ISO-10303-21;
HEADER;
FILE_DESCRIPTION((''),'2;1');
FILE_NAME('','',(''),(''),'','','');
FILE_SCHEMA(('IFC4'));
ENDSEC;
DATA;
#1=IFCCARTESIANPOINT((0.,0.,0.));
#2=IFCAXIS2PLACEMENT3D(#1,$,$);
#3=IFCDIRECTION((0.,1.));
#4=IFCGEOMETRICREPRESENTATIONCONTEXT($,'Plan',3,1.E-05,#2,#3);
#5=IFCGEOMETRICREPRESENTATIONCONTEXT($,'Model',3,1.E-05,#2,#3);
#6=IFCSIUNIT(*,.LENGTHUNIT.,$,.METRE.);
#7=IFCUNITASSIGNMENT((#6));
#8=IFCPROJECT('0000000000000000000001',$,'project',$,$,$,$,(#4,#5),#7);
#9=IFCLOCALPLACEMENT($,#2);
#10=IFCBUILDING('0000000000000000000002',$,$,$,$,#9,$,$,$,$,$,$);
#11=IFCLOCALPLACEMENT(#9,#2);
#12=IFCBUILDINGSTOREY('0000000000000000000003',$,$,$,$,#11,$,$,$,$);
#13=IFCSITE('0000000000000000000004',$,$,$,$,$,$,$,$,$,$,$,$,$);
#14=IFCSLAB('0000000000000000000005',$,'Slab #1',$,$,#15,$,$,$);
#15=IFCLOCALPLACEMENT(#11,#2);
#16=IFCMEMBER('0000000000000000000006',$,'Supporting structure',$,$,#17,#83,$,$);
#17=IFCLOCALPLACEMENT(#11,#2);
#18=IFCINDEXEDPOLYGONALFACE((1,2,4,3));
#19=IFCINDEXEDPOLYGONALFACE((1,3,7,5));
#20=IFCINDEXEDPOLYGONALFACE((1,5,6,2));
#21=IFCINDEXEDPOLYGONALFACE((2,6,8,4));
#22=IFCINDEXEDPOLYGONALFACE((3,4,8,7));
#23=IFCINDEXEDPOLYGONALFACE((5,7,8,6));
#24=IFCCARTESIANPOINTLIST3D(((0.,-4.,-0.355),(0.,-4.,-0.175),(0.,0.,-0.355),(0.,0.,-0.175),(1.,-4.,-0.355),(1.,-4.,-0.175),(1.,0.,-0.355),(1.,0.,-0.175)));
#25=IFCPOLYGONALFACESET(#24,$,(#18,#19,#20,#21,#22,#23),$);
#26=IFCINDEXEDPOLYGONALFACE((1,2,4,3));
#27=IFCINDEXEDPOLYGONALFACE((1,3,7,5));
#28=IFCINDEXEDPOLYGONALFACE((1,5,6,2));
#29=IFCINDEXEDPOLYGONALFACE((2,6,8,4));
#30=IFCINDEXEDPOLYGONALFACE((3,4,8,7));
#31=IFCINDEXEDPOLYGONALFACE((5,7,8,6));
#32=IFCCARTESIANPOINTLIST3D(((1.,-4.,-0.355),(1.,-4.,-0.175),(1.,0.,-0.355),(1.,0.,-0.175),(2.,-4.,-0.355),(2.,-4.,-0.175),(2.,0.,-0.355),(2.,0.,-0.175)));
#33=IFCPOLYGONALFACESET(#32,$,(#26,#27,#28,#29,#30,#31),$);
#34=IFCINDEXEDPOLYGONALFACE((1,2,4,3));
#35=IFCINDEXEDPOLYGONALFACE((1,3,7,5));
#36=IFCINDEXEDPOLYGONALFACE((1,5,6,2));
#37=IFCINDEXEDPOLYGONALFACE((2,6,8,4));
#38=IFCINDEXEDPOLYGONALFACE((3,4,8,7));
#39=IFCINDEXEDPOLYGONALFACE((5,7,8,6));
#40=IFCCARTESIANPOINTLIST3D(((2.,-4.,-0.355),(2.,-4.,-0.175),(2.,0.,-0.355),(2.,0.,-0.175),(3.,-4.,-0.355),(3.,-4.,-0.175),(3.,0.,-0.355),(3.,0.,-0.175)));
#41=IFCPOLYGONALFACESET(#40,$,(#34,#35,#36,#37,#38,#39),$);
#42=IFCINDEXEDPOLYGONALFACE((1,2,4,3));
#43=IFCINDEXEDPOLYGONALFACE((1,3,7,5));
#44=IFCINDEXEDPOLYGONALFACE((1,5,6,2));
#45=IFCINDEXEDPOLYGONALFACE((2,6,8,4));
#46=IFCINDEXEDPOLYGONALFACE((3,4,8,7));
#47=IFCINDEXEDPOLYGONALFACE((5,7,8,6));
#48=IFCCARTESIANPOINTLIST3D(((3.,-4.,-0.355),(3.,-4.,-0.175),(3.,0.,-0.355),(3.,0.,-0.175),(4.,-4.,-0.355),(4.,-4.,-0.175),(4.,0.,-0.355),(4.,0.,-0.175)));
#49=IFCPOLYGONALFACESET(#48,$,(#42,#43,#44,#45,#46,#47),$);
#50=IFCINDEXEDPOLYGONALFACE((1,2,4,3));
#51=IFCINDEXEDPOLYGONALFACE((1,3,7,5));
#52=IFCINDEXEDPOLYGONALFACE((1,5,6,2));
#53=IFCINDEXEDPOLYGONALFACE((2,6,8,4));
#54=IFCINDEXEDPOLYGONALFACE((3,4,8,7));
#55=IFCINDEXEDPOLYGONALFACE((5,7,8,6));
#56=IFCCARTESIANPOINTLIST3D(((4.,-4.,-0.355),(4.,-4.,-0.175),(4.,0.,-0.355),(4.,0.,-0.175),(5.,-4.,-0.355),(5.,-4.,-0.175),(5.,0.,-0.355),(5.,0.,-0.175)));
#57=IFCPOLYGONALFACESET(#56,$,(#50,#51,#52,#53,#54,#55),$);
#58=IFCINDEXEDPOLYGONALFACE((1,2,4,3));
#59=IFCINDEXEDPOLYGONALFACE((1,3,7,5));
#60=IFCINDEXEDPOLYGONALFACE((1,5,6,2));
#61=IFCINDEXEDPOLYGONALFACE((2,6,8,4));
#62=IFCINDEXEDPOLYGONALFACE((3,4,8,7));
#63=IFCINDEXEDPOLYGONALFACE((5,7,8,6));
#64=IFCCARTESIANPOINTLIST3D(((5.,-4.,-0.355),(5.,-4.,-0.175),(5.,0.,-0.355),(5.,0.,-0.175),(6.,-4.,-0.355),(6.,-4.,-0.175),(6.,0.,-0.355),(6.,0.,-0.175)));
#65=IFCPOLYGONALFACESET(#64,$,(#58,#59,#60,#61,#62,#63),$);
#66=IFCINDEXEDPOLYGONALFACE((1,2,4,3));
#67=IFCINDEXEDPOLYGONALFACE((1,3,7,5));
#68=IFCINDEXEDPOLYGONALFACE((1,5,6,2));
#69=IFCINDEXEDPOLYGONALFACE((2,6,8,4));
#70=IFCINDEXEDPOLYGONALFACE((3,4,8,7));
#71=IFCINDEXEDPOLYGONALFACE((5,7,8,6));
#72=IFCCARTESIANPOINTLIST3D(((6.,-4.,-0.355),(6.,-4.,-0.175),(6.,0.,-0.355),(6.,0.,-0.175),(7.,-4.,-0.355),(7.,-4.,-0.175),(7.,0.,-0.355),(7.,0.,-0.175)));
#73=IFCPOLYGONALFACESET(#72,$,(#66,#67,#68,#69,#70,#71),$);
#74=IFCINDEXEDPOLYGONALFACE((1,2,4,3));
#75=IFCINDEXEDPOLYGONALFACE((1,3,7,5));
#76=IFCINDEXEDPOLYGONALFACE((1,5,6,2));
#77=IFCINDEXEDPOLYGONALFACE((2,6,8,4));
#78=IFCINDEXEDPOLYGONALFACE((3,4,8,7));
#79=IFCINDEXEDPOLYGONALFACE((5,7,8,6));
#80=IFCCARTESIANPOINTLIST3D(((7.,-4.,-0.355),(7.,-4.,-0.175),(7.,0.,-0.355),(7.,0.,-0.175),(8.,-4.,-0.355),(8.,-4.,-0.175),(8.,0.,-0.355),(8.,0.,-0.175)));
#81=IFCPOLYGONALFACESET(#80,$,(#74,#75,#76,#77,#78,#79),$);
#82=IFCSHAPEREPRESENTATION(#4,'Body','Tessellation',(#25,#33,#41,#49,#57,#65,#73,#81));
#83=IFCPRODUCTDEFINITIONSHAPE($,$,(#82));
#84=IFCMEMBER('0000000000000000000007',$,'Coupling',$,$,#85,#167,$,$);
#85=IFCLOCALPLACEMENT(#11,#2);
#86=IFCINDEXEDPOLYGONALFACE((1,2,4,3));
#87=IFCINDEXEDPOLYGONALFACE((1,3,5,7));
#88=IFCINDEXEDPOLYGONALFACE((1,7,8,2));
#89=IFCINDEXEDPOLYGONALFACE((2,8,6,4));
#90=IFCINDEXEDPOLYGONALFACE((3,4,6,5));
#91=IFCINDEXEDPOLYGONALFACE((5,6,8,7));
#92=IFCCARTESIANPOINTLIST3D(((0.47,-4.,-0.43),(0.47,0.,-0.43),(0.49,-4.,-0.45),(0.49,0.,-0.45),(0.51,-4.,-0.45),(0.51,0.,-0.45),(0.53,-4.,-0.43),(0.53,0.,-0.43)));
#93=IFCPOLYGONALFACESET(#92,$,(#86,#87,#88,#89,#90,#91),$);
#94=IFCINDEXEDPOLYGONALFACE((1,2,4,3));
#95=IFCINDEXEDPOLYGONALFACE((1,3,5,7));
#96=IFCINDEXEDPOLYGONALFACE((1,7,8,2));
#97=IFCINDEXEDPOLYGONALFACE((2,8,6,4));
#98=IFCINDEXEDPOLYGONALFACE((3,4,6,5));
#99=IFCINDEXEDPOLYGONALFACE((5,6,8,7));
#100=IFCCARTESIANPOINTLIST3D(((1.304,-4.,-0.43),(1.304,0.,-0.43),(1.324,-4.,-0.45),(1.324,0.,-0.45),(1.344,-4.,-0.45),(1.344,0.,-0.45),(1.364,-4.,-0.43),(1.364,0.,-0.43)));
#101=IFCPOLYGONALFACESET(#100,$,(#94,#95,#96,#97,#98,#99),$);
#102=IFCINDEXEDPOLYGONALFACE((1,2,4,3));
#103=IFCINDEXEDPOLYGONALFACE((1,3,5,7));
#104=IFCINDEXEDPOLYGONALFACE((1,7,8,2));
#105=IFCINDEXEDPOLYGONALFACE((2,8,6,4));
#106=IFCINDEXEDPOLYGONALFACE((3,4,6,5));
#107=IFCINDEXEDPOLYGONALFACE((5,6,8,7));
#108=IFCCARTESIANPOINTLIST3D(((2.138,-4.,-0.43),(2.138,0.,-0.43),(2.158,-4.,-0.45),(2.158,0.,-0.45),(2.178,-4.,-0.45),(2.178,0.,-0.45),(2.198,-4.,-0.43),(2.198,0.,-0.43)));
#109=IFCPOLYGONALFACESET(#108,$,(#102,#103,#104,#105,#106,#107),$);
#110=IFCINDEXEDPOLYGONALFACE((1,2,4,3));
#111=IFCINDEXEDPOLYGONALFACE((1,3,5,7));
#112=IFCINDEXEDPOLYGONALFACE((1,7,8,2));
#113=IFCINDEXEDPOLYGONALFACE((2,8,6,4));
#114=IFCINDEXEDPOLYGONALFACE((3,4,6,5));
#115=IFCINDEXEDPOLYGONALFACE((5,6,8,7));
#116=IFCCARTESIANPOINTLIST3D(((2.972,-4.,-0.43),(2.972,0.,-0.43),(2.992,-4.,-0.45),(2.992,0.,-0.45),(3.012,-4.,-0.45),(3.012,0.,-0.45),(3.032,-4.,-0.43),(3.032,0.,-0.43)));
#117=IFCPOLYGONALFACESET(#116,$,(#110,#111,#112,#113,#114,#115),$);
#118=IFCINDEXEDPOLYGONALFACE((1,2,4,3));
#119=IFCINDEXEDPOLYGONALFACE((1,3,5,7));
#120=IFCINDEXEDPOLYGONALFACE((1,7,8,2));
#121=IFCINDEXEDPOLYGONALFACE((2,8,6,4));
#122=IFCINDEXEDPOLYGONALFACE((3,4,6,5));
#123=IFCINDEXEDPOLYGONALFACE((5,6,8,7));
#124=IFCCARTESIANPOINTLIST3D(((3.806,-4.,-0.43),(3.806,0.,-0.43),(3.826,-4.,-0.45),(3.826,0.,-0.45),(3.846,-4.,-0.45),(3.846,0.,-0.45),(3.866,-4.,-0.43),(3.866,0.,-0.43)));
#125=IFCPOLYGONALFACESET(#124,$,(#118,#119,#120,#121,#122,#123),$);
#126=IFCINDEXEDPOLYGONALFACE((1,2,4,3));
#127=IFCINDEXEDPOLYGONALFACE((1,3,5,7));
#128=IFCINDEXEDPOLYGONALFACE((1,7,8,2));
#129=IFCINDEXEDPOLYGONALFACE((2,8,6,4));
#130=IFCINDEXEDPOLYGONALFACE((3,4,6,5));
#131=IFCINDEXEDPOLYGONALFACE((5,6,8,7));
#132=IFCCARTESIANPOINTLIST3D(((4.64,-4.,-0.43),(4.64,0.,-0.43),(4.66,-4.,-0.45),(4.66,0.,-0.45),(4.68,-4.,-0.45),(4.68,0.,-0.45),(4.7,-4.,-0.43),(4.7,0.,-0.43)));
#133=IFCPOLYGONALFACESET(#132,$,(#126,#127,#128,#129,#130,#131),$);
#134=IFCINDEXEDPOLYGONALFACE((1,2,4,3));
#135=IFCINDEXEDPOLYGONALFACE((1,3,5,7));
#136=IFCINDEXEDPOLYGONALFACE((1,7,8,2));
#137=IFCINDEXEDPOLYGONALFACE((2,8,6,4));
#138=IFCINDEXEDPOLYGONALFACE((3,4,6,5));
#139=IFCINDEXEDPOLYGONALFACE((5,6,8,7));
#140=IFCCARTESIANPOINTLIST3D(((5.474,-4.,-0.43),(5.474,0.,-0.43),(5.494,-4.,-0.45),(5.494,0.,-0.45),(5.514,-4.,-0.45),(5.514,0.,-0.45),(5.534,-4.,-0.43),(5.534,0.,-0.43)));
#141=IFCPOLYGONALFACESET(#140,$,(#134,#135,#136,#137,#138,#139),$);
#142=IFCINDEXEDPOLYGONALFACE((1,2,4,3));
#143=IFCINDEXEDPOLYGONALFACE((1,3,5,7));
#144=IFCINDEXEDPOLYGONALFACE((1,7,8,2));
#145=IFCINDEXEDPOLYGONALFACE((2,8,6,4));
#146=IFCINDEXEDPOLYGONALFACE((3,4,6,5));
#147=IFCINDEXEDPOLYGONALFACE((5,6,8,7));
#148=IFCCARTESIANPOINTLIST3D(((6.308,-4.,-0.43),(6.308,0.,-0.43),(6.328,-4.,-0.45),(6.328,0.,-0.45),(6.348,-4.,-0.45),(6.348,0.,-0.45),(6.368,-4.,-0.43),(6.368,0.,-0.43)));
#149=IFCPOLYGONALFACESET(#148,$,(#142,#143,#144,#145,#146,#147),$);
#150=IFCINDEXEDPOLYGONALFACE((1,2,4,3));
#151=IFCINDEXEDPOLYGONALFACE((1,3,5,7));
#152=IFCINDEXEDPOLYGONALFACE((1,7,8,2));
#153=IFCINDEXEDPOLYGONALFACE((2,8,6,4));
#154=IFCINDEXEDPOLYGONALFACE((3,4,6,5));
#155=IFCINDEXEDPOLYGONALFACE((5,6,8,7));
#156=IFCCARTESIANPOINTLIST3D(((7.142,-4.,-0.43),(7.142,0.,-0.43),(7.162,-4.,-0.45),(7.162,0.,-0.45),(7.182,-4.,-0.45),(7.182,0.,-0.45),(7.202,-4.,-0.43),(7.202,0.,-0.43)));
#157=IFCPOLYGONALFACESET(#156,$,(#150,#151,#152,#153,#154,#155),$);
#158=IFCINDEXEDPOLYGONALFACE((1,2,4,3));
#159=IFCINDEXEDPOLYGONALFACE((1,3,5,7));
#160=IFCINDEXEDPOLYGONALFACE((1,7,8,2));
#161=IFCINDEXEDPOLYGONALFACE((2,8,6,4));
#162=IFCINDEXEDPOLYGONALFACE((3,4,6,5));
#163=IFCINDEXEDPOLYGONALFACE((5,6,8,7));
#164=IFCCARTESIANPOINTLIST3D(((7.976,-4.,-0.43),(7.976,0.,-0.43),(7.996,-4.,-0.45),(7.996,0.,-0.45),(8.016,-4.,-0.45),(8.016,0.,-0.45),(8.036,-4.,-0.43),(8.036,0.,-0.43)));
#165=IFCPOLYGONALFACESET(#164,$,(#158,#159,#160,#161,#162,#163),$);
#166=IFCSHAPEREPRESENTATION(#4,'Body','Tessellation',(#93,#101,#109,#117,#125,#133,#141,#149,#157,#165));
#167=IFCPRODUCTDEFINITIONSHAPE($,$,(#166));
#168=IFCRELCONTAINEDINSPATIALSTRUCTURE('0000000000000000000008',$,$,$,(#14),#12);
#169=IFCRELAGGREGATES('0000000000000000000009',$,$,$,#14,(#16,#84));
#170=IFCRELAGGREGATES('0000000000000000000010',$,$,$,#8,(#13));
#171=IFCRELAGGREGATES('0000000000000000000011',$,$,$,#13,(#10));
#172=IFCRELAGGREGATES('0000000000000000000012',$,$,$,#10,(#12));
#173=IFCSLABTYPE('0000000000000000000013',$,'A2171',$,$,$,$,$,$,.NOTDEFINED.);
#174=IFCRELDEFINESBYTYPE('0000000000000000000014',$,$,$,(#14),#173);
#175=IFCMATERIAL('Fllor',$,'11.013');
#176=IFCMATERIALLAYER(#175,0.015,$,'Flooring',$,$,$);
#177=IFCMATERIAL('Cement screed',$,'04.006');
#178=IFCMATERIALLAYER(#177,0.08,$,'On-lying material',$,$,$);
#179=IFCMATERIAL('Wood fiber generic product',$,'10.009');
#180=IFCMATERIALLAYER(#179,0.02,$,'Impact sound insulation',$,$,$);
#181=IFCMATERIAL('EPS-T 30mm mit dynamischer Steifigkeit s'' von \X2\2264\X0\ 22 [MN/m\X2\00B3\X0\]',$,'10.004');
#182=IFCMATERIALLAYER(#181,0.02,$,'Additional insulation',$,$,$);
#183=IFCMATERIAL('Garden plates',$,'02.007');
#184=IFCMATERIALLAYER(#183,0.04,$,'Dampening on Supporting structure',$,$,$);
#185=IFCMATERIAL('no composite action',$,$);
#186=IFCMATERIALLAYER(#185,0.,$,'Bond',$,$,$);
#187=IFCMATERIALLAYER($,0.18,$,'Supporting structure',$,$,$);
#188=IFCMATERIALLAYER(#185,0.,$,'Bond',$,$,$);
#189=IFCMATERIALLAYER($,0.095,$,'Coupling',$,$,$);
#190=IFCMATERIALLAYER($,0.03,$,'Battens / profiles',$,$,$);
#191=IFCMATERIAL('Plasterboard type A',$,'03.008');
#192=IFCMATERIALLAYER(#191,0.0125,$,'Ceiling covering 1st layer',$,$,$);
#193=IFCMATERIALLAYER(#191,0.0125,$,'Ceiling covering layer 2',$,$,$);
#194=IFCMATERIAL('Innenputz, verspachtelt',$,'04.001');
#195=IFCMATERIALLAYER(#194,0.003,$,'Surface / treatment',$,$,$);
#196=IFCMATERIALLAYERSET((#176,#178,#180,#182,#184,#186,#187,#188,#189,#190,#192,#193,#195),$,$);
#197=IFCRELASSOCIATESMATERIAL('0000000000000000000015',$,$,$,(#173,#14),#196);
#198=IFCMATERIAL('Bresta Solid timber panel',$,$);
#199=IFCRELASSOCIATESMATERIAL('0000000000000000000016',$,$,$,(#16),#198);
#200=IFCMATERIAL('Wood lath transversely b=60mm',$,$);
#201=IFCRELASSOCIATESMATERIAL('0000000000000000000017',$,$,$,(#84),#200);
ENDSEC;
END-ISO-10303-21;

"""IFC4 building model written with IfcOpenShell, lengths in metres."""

from ifc_helpers import new_model, si_unit, direction, frame, frame_2d, origin, place, context, project, spatial, polyline, rectangle, outline, extrude, material, layer, layer_set, type_object, element, aggregate, save


model = new_model("IFC4")

# Units and contexts
plan_context = context("Plan", 3, precision=1e-05, world=origin(), true_north=direction((0.0, 1.0)))
model_context = context("Model", 3, precision=1e-05, world=origin(), true_north=direction((0.0, 1.0)))
ifc_project = project(units=[si_unit("LENGTHUNIT", "METRE")], contexts=[plan_context, model_context])

# Site, building, storey
site = spatial("IfcSite", under=ifc_project)
building_placement = place(None, origin())
building = spatial("IfcBuilding", under=site, at=building_placement)
storey_placement = place(building_placement, origin())
storey = spatial("IfcBuildingStorey", under=building, at=storey_placement)

# Slab, members
ifc_material_1 = material(Name="Fllor", Category="11.013")
ifc_layer_1 = layer(ifc_material_1, 0.015, Name="Flooring")
ifc_material_2 = material(Name="Cement screed", Category="04.006")
ifc_layer_2 = layer(ifc_material_2, 0.08, Name="On-lying material")
ifc_material_3 = material(Name="Wood fiber generic product", Category="10.009")
ifc_layer_3 = layer(ifc_material_3, 0.02, Name="Impact sound insulation")
ifc_material_4 = material(Name="EPS-T 30mm mit dynamischer Steifigkeit s' von ≤ 22 [MN/m³]", Category="10.004")
ifc_layer_4 = layer(ifc_material_4, 0.02, Name="Additional insulation")
ifc_material_5 = material(Name="Garden plates", Category="02.007")
ifc_layer_5 = layer(ifc_material_5, 0.04, Name="Dampening on Supporting structure")
ifc_material_6 = material(Name="no composite action")
ifc_layer_6 = layer(ifc_material_6, 0.0, Name="Bond")
ifc_layer_7 = layer(None, 0.18, Name="Supporting structure")
ifc_layer_8 = layer(ifc_material_6, 0.0, Name="Bond")
ifc_layer_9 = layer(None, 0.095, Name="Coupling")
ifc_layer_10 = layer(None, 0.03, Name="Battens / profiles")
ifc_material_7 = material(Name="Plasterboard type A", Category="03.008")
ifc_layer_11 = layer(ifc_material_7, 0.0125, Name="Ceiling covering 1st layer")
ifc_layer_12 = layer(ifc_material_7, 0.0125, Name="Ceiling covering layer 2")
ifc_material_8 = material(Name="Innenputz, verspachtelt", Category="04.001")
ifc_layer_13 = layer(ifc_material_8, 0.003, Name="Surface / treatment")
ifc_layer_set = layer_set([ifc_layer_1, ifc_layer_2, ifc_layer_3, ifc_layer_4, ifc_layer_5, ifc_layer_6, ifc_layer_7, ifc_layer_8, ifc_layer_9, ifc_layer_10, ifc_layer_11, ifc_layer_12, ifc_layer_13])
slab_type = type_object("IfcSlabType", Name="A2171", PredefinedType="NOTDEFINED", material=ifc_layer_set)
slab_placement = place(None, frame((0.0, 0.0, 0.0), z_axis=(0.0, 0.0, -1.0), x_axis=(1.0, 0.0, 0.0)))
slab = element("IfcSlab", 1, at=slab_placement, inside=storey, type_object=slab_type, material=ifc_layer_set, Name="Slab #1")
ifc_material_9 = material(Name="Bresta Solid timber panel")
member_1_placement = place(slab_placement, origin())
member_1 = element("IfcMember", 2, at=member_1_placement, material=ifc_material_9, Name="Supporting structure", context=plan_context, shape_type="SweptSolid", body=[
    extrude(rectangle(XDim=1.0, YDim=0.18, at=frame_2d((0.5, 0.09), x_axis=(1.0, 0.0))), frame((0.0, 4.0, 0.175), z_axis=(0.0, -1.0, 0.0), x_axis=(1.0, 0.0, 0.0)), (0.0, 0.0, 1.0), 4.0),
    extrude(rectangle(XDim=1.0, YDim=0.18, at=frame_2d((0.5, 0.09), x_axis=(1.0, 0.0))), frame((1.0, 4.0, 0.175), z_axis=(0.0, -1.0, 0.0), x_axis=(1.0, 0.0, 0.0)), (0.0, 0.0, 1.0), 4.0),
    extrude(rectangle(XDim=1.0, YDim=0.18, at=frame_2d((0.5, 0.09), x_axis=(1.0, 0.0))), frame((2.0, 4.0, 0.175), z_axis=(0.0, -1.0, 0.0), x_axis=(1.0, 0.0, 0.0)), (0.0, 0.0, 1.0), 4.0),
    extrude(rectangle(XDim=1.0, YDim=0.18, at=frame_2d((0.5, 0.09), x_axis=(1.0, 0.0))), frame((3.0, 4.0, 0.175), z_axis=(0.0, -1.0, 0.0), x_axis=(1.0, 0.0, 0.0)), (0.0, 0.0, 1.0), 4.0),
    extrude(rectangle(XDim=1.0, YDim=0.18, at=frame_2d((0.5, 0.09), x_axis=(1.0, 0.0))), frame((4.0, 4.0, 0.175), z_axis=(0.0, -1.0, 0.0), x_axis=(1.0, 0.0, 0.0)), (0.0, 0.0, 1.0), 4.0),
    extrude(rectangle(XDim=1.0, YDim=0.18, at=frame_2d((0.5, 0.09), x_axis=(1.0, 0.0))), frame((5.0, 4.0, 0.175), z_axis=(0.0, -1.0, 0.0), x_axis=(1.0, 0.0, 0.0)), (0.0, 0.0, 1.0), 4.0),
    extrude(rectangle(XDim=1.0, YDim=0.18, at=frame_2d((0.5, 0.09), x_axis=(1.0, 0.0))), frame((6.0, 4.0, 0.175), z_axis=(0.0, -1.0, 0.0), x_axis=(1.0, 0.0, 0.0)), (0.0, 0.0, 1.0), 4.0),
    extrude(rectangle(XDim=1.0, YDim=0.18, at=frame_2d((0.5, 0.09), x_axis=(1.0, 0.0))), frame((7.0, 4.0, 0.175), z_axis=(0.0, -1.0, 0.0), x_axis=(1.0, 0.0, 0.0)), (0.0, 0.0, 1.0), 4.0),
])
ifc_material_10 = material(Name="Wood lath transversely b=60mm")
member_2_placement = place(slab_placement, origin())
member_2 = element("IfcMember", 3, at=member_2_placement, material=ifc_material_10, Name="Coupling", context=plan_context, shape_type="SweptSolid", body=[
    extrude(outline(polyline([(0.0, 0.0), (0.06, 0.0), (0.04, 0.02), (0.02, 0.02), (0.0, 0.0)])), frame((0.47, 4.0, 0.43), z_axis=(0.0, -1.0, 0.0), x_axis=(1.0, 0.0, 0.0)), (0.0, 0.0, 1.0), 4.0),
    extrude(outline(polyline([(0.0, 0.0), (0.06, 0.0), (0.04, 0.02), (0.02, 0.02), (0.0, 0.0)])), frame((1.304, 4.0, 0.43), z_axis=(0.0, -1.0, 0.0), x_axis=(1.0, 0.0, 0.0)), (0.0, 0.0, 1.0), 4.0),
    extrude(outline(polyline([(0.0, 0.0), (0.06, 0.0), (0.04, 0.02), (0.02, 0.02), (0.0, 0.0)])), frame((2.138, 4.0, 0.43), z_axis=(0.0, -1.0, 0.0), x_axis=(1.0, 0.0, 0.0)), (0.0, 0.0, 1.0), 4.0),
    extrude(outline(polyline([(0.0, 0.0), (0.06, 0.0), (0.04, 0.02), (0.02, 0.02), (0.0, 0.0)])), frame((2.972, 4.0, 0.43), z_axis=(0.0, -1.0, 0.0), x_axis=(1.0, 0.0, 0.0)), (0.0, 0.0, 1.0), 4.0),
    extrude(outline(polyline([(0.0, 0.0), (0.06, 0.0), (0.04, 0.02), (0.02, 0.02), (0.0, 0.0)])), frame((3.806, 4.0, 0.43), z_axis=(0.0, -1.0, 0.0), x_axis=(1.0, 0.0, 0.0)), (0.0, 0.0, 1.0), 4.0),
    extrude(outline(polyline([(0.0, 0.0), (0.06, 0.0), (0.04, 0.02), (0.02, 0.02), (0.0, 0.0)])), frame((4.64, 4.0, 0.43), z_axis=(0.0, -1.0, 0.0), x_axis=(1.0, 0.0, 0.0)), (0.0, 0.0, 1.0), 4.0),
    extrude(outline(polyline([(0.0, 0.0), (0.06, 0.0), (0.04, 0.02), (0.02, 0.02), (0.0, 0.0)])), frame((5.474, 4.0, 0.43), z_axis=(0.0, -1.0, 0.0), x_axis=(1.0, 0.0, 0.0)), (0.0, 0.0, 1.0), 4.0),
    extrude(outline(polyline([(0.0, 0.0), (0.06, 0.0), (0.04, 0.02), (0.02, 0.02), (0.0, 0.0)])), frame((6.308, 4.0, 0.43), z_axis=(0.0, -1.0, 0.0), x_axis=(1.0, 0.0, 0.0)), (0.0, 0.0, 1.0), 4.0),
    extrude(outline(polyline([(0.0, 0.0), (0.06, 0.0), (0.04, 0.02), (0.02, 0.02), (0.0, 0.0)])), frame((7.142, 4.0, 0.43), z_axis=(0.0, -1.0, 0.0), x_axis=(1.0, 0.0, 0.0)), (0.0, 0.0, 1.0), 4.0),
    extrude(outline(polyline([(0.0, 0.0), (0.06, 0.0), (0.04, 0.02), (0.02, 0.02), (0.0, 0.0)])), frame((7.976, 4.0, 0.43), z_axis=(0.0, -1.0, 0.0), x_axis=(1.0, 0.0, 0.0)), (0.0, 0.0, 1.0), 4.0),
])
aggregate(slab, [member_1, member_2])

save(model, "model.ifc")
